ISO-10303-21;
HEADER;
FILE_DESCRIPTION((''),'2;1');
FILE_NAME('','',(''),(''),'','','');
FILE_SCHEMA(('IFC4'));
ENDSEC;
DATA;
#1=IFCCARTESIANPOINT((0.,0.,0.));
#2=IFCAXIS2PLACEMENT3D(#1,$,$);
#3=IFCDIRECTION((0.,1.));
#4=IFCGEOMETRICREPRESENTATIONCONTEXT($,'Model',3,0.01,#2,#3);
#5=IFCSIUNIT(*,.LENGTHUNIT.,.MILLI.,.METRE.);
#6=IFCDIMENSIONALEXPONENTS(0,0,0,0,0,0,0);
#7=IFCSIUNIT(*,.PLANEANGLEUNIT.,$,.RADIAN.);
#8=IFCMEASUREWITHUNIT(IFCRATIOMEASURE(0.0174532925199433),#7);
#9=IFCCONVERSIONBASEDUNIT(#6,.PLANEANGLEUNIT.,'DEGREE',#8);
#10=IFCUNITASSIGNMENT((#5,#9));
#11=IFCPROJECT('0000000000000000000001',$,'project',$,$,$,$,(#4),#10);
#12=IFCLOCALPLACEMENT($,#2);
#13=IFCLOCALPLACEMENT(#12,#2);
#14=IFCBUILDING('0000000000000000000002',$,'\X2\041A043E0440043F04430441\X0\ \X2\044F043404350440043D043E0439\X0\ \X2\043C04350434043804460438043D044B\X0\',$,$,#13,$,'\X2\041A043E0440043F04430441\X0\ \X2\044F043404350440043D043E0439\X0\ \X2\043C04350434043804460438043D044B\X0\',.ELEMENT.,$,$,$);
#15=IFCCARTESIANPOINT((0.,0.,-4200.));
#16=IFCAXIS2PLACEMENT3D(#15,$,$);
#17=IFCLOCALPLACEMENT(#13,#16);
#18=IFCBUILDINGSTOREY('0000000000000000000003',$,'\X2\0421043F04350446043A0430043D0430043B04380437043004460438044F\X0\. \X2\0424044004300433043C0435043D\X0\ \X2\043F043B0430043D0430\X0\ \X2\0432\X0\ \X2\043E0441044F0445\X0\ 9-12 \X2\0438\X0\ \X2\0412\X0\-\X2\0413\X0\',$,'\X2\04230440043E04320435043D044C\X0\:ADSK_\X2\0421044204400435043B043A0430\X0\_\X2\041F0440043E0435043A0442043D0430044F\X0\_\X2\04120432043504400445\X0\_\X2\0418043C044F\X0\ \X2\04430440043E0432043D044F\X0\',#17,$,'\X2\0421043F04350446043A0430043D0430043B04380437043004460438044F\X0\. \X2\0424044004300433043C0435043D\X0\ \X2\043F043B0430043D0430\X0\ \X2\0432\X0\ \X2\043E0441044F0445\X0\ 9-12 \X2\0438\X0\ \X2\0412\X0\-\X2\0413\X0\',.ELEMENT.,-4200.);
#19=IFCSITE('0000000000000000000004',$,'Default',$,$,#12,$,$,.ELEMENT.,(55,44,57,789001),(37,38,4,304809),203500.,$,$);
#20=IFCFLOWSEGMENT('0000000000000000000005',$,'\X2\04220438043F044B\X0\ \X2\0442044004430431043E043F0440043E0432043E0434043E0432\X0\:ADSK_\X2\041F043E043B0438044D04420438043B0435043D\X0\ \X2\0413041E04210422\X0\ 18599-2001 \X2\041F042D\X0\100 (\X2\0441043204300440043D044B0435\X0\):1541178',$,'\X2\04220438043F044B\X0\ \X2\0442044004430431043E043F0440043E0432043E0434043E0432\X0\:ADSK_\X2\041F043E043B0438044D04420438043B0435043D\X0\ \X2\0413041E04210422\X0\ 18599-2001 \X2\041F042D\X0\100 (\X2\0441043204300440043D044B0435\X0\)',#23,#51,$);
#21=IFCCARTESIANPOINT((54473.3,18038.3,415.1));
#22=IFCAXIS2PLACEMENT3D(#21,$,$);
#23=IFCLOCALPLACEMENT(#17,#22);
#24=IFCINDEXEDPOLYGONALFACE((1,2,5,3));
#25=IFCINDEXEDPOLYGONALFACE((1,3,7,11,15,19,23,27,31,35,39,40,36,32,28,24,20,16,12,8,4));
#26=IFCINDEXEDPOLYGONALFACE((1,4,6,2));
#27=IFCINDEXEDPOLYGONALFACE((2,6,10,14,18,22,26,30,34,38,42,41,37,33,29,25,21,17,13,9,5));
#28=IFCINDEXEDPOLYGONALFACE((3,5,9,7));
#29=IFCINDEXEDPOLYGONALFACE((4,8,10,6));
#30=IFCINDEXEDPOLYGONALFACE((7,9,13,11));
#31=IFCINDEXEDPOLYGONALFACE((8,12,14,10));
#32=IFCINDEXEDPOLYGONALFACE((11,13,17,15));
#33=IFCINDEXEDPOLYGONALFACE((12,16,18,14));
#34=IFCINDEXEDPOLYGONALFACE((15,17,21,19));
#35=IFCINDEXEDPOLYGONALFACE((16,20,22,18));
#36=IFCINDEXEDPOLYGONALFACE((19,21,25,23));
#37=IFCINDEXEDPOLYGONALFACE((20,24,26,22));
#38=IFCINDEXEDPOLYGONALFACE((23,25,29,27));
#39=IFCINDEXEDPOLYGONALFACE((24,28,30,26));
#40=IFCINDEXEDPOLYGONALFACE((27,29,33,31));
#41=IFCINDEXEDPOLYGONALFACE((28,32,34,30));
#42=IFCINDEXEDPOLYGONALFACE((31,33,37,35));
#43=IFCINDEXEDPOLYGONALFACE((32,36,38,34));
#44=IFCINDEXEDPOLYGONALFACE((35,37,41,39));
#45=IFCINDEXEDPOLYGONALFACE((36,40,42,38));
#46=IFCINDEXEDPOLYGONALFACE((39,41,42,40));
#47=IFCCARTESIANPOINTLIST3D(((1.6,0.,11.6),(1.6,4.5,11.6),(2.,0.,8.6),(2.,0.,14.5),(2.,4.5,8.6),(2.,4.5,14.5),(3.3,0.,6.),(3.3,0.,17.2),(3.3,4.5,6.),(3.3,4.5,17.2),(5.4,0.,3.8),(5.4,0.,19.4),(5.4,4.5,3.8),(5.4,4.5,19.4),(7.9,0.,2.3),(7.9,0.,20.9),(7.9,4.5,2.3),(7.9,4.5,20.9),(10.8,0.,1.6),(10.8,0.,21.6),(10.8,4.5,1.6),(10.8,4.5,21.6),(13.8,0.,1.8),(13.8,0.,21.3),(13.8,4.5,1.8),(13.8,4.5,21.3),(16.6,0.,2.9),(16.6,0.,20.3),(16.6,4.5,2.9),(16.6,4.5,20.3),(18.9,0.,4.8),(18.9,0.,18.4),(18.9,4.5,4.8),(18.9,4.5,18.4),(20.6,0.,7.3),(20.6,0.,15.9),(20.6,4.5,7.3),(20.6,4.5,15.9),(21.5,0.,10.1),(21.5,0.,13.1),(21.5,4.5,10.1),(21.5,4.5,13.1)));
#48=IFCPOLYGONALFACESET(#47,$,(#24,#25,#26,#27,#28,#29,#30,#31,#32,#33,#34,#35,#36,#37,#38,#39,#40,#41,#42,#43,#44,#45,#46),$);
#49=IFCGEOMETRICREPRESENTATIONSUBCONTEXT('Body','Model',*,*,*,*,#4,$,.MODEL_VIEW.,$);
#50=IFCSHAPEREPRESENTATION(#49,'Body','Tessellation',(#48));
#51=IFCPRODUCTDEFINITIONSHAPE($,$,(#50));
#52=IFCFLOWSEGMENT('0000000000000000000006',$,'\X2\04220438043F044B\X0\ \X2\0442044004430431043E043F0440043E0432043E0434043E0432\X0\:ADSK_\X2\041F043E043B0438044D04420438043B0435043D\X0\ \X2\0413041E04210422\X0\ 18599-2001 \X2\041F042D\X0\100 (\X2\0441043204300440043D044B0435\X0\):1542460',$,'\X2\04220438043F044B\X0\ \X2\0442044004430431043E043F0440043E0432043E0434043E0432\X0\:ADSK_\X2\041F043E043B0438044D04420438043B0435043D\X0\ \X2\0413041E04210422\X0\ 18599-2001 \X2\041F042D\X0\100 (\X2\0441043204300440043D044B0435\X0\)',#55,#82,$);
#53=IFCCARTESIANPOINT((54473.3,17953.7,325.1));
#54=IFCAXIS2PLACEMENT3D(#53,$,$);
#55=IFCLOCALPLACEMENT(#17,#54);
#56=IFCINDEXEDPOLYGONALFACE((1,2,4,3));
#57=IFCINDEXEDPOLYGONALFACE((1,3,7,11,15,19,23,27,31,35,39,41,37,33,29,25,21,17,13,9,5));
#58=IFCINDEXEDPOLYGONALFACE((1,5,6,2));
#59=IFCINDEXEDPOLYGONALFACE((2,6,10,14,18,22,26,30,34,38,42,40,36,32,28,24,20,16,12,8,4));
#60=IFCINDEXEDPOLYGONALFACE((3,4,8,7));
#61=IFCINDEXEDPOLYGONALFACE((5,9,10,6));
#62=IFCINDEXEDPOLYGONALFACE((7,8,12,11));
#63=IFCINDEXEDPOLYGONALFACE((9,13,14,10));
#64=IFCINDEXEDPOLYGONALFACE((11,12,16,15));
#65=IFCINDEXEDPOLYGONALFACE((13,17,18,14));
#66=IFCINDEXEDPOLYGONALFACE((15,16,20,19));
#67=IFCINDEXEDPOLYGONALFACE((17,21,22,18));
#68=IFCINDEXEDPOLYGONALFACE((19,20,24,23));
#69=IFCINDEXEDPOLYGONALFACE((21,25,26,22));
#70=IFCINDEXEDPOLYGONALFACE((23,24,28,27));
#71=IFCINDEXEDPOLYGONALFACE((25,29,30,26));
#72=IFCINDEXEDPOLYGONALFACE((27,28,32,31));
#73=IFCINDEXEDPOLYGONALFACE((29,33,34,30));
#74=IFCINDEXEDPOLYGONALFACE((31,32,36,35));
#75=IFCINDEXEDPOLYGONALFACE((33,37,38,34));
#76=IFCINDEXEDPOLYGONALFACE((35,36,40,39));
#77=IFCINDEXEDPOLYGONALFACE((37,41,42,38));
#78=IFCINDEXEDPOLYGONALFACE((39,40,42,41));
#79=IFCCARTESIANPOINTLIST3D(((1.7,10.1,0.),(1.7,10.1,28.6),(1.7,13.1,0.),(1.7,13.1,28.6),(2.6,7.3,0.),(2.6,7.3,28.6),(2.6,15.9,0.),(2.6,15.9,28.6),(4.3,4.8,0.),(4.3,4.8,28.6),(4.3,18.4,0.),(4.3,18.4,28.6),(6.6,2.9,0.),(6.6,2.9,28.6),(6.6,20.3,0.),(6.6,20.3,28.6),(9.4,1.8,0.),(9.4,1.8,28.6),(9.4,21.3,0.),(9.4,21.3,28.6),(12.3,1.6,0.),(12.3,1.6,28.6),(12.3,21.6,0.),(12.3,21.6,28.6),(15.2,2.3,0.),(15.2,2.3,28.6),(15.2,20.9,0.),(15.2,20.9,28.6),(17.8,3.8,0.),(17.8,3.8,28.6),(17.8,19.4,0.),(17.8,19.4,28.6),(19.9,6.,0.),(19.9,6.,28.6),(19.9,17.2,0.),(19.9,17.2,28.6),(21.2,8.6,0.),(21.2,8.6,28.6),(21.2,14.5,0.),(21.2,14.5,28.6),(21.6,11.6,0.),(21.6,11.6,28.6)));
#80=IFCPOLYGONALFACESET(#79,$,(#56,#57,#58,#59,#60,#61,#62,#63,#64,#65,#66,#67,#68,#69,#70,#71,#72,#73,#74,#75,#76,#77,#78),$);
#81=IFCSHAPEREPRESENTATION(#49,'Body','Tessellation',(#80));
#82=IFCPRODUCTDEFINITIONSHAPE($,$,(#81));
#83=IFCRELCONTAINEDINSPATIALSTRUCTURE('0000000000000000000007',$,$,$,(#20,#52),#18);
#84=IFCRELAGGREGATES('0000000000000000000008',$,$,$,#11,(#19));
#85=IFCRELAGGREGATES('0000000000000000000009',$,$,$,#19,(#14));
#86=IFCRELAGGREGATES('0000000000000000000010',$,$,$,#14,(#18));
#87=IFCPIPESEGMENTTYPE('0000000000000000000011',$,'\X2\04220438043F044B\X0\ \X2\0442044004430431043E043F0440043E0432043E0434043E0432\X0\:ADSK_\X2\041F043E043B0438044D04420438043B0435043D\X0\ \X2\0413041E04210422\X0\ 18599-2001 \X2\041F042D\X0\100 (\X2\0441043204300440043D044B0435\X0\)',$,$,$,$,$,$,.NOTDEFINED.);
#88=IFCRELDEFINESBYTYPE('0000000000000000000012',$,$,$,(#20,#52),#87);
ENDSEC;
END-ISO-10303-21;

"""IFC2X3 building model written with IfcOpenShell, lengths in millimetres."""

from ifc_helpers import new_model, entity, si_unit, converted_unit, direction, frame, origin, origin_2d_with_axis, place, context, subcontext, project, spatial, circle, extrude, type_object, element, save


model = new_model("IFC2X3")

# Units and contexts
model_context = context("Model", 3, precision=0.01, world=origin(), true_north=direction((0.0, 1.0)))
body_context = subcontext(model_context, "Body", "Model", "MODEL_VIEW")
ifc_project = project(units=[si_unit("LENGTHUNIT", "METRE", prefix="MILLI"), converted_unit("PLANEANGLEUNIT", "DEGREE", entity("IfcRatioMeasure", 0.0174532925199433), si_unit("PLANEANGLEUNIT", "RADIAN"), dimensions=[0, 0, 0, 0, 0, 0, 0])], contexts=[model_context])

# Site, building, storey
site_placement = place(None, frame((0.0, 0.0, 0.0)))
site = spatial("IfcSite", under=ifc_project, at=site_placement, Name="Default", CompositionType="ELEMENT", RefLatitude=(55, 44, 57, 789001), RefLongitude=(37, 38, 4, 304809), RefElevation=203500.0)
building_placement = place(site_placement, origin())
building = spatial("IfcBuilding", under=site, at=building_placement, Name="Корпус ядерной медицины", LongName="Корпус ядерной медицины", CompositionType="ELEMENT")
storey_placement = place(building_placement, frame((0.0, 0.0, -4200.0)))
storey = spatial("IfcBuildingStorey", under=building, at=storey_placement, Name="Спецканализация. Фрагмен плана в осях 9-12 и В-Г", ObjectType="Уровень:ADSK_Стрелка_Проектная_Вверх_Имя уровня", LongName="Спецканализация. Фрагмен плана в осях 9-12 и В-Г", CompositionType="ELEMENT", Elevation=-4200.0)

# Flow segments
pipe_segment_type = type_object("IfcPipeSegmentType", Name="Типы трубопроводов:ADSK_Полиэтилен ГОСТ 18599-2001 ПЭ100 (сварные)", PredefinedType="NOTDEFINED")
flow_segment_1_placement = place(storey_placement, frame((54473.3, 18038.3, 415.1)))
element("IfcFlowSegment", 1, at=flow_segment_1_placement, inside=storey, type_object=pipe_segment_type, Name="Типы трубопроводов:ADSK_Полиэтилен ГОСТ 18599-2001 ПЭ100 (сварные):1541178", ObjectType="Типы трубопроводов:ADSK_Полиэтилен ГОСТ 18599-2001 ПЭ100 (сварные)", context=body_context, shape_type="SweptSolid", body=[
    extrude(circle(Radius=10.0, at=origin_2d_with_axis()), frame((11.6, 0.0, 11.6), z_axis=(0.0, 1.0, 0.0), x_axis=(-1.0, 0.0, 0.0)), (0.0, 0.0, 1.0), 4.5),
])
flow_segment_2_placement = place(storey_placement, frame((54473.3, 17953.7, 325.1)))
element("IfcFlowSegment", 2, at=flow_segment_2_placement, inside=storey, type_object=pipe_segment_type, Name="Типы трубопроводов:ADSK_Полиэтилен ГОСТ 18599-2001 ПЭ100 (сварные):1542460", ObjectType="Типы трубопроводов:ADSK_Полиэтилен ГОСТ 18599-2001 ПЭ100 (сварные)", context=body_context, shape_type="SweptSolid", body=[
    extrude(circle(Radius=10.0, at=origin_2d_with_axis()), frame((11.6, 11.6, 0.0)), (0.0, 0.0, 1.0), 28.6),
])

save(model, "model.ifc")
